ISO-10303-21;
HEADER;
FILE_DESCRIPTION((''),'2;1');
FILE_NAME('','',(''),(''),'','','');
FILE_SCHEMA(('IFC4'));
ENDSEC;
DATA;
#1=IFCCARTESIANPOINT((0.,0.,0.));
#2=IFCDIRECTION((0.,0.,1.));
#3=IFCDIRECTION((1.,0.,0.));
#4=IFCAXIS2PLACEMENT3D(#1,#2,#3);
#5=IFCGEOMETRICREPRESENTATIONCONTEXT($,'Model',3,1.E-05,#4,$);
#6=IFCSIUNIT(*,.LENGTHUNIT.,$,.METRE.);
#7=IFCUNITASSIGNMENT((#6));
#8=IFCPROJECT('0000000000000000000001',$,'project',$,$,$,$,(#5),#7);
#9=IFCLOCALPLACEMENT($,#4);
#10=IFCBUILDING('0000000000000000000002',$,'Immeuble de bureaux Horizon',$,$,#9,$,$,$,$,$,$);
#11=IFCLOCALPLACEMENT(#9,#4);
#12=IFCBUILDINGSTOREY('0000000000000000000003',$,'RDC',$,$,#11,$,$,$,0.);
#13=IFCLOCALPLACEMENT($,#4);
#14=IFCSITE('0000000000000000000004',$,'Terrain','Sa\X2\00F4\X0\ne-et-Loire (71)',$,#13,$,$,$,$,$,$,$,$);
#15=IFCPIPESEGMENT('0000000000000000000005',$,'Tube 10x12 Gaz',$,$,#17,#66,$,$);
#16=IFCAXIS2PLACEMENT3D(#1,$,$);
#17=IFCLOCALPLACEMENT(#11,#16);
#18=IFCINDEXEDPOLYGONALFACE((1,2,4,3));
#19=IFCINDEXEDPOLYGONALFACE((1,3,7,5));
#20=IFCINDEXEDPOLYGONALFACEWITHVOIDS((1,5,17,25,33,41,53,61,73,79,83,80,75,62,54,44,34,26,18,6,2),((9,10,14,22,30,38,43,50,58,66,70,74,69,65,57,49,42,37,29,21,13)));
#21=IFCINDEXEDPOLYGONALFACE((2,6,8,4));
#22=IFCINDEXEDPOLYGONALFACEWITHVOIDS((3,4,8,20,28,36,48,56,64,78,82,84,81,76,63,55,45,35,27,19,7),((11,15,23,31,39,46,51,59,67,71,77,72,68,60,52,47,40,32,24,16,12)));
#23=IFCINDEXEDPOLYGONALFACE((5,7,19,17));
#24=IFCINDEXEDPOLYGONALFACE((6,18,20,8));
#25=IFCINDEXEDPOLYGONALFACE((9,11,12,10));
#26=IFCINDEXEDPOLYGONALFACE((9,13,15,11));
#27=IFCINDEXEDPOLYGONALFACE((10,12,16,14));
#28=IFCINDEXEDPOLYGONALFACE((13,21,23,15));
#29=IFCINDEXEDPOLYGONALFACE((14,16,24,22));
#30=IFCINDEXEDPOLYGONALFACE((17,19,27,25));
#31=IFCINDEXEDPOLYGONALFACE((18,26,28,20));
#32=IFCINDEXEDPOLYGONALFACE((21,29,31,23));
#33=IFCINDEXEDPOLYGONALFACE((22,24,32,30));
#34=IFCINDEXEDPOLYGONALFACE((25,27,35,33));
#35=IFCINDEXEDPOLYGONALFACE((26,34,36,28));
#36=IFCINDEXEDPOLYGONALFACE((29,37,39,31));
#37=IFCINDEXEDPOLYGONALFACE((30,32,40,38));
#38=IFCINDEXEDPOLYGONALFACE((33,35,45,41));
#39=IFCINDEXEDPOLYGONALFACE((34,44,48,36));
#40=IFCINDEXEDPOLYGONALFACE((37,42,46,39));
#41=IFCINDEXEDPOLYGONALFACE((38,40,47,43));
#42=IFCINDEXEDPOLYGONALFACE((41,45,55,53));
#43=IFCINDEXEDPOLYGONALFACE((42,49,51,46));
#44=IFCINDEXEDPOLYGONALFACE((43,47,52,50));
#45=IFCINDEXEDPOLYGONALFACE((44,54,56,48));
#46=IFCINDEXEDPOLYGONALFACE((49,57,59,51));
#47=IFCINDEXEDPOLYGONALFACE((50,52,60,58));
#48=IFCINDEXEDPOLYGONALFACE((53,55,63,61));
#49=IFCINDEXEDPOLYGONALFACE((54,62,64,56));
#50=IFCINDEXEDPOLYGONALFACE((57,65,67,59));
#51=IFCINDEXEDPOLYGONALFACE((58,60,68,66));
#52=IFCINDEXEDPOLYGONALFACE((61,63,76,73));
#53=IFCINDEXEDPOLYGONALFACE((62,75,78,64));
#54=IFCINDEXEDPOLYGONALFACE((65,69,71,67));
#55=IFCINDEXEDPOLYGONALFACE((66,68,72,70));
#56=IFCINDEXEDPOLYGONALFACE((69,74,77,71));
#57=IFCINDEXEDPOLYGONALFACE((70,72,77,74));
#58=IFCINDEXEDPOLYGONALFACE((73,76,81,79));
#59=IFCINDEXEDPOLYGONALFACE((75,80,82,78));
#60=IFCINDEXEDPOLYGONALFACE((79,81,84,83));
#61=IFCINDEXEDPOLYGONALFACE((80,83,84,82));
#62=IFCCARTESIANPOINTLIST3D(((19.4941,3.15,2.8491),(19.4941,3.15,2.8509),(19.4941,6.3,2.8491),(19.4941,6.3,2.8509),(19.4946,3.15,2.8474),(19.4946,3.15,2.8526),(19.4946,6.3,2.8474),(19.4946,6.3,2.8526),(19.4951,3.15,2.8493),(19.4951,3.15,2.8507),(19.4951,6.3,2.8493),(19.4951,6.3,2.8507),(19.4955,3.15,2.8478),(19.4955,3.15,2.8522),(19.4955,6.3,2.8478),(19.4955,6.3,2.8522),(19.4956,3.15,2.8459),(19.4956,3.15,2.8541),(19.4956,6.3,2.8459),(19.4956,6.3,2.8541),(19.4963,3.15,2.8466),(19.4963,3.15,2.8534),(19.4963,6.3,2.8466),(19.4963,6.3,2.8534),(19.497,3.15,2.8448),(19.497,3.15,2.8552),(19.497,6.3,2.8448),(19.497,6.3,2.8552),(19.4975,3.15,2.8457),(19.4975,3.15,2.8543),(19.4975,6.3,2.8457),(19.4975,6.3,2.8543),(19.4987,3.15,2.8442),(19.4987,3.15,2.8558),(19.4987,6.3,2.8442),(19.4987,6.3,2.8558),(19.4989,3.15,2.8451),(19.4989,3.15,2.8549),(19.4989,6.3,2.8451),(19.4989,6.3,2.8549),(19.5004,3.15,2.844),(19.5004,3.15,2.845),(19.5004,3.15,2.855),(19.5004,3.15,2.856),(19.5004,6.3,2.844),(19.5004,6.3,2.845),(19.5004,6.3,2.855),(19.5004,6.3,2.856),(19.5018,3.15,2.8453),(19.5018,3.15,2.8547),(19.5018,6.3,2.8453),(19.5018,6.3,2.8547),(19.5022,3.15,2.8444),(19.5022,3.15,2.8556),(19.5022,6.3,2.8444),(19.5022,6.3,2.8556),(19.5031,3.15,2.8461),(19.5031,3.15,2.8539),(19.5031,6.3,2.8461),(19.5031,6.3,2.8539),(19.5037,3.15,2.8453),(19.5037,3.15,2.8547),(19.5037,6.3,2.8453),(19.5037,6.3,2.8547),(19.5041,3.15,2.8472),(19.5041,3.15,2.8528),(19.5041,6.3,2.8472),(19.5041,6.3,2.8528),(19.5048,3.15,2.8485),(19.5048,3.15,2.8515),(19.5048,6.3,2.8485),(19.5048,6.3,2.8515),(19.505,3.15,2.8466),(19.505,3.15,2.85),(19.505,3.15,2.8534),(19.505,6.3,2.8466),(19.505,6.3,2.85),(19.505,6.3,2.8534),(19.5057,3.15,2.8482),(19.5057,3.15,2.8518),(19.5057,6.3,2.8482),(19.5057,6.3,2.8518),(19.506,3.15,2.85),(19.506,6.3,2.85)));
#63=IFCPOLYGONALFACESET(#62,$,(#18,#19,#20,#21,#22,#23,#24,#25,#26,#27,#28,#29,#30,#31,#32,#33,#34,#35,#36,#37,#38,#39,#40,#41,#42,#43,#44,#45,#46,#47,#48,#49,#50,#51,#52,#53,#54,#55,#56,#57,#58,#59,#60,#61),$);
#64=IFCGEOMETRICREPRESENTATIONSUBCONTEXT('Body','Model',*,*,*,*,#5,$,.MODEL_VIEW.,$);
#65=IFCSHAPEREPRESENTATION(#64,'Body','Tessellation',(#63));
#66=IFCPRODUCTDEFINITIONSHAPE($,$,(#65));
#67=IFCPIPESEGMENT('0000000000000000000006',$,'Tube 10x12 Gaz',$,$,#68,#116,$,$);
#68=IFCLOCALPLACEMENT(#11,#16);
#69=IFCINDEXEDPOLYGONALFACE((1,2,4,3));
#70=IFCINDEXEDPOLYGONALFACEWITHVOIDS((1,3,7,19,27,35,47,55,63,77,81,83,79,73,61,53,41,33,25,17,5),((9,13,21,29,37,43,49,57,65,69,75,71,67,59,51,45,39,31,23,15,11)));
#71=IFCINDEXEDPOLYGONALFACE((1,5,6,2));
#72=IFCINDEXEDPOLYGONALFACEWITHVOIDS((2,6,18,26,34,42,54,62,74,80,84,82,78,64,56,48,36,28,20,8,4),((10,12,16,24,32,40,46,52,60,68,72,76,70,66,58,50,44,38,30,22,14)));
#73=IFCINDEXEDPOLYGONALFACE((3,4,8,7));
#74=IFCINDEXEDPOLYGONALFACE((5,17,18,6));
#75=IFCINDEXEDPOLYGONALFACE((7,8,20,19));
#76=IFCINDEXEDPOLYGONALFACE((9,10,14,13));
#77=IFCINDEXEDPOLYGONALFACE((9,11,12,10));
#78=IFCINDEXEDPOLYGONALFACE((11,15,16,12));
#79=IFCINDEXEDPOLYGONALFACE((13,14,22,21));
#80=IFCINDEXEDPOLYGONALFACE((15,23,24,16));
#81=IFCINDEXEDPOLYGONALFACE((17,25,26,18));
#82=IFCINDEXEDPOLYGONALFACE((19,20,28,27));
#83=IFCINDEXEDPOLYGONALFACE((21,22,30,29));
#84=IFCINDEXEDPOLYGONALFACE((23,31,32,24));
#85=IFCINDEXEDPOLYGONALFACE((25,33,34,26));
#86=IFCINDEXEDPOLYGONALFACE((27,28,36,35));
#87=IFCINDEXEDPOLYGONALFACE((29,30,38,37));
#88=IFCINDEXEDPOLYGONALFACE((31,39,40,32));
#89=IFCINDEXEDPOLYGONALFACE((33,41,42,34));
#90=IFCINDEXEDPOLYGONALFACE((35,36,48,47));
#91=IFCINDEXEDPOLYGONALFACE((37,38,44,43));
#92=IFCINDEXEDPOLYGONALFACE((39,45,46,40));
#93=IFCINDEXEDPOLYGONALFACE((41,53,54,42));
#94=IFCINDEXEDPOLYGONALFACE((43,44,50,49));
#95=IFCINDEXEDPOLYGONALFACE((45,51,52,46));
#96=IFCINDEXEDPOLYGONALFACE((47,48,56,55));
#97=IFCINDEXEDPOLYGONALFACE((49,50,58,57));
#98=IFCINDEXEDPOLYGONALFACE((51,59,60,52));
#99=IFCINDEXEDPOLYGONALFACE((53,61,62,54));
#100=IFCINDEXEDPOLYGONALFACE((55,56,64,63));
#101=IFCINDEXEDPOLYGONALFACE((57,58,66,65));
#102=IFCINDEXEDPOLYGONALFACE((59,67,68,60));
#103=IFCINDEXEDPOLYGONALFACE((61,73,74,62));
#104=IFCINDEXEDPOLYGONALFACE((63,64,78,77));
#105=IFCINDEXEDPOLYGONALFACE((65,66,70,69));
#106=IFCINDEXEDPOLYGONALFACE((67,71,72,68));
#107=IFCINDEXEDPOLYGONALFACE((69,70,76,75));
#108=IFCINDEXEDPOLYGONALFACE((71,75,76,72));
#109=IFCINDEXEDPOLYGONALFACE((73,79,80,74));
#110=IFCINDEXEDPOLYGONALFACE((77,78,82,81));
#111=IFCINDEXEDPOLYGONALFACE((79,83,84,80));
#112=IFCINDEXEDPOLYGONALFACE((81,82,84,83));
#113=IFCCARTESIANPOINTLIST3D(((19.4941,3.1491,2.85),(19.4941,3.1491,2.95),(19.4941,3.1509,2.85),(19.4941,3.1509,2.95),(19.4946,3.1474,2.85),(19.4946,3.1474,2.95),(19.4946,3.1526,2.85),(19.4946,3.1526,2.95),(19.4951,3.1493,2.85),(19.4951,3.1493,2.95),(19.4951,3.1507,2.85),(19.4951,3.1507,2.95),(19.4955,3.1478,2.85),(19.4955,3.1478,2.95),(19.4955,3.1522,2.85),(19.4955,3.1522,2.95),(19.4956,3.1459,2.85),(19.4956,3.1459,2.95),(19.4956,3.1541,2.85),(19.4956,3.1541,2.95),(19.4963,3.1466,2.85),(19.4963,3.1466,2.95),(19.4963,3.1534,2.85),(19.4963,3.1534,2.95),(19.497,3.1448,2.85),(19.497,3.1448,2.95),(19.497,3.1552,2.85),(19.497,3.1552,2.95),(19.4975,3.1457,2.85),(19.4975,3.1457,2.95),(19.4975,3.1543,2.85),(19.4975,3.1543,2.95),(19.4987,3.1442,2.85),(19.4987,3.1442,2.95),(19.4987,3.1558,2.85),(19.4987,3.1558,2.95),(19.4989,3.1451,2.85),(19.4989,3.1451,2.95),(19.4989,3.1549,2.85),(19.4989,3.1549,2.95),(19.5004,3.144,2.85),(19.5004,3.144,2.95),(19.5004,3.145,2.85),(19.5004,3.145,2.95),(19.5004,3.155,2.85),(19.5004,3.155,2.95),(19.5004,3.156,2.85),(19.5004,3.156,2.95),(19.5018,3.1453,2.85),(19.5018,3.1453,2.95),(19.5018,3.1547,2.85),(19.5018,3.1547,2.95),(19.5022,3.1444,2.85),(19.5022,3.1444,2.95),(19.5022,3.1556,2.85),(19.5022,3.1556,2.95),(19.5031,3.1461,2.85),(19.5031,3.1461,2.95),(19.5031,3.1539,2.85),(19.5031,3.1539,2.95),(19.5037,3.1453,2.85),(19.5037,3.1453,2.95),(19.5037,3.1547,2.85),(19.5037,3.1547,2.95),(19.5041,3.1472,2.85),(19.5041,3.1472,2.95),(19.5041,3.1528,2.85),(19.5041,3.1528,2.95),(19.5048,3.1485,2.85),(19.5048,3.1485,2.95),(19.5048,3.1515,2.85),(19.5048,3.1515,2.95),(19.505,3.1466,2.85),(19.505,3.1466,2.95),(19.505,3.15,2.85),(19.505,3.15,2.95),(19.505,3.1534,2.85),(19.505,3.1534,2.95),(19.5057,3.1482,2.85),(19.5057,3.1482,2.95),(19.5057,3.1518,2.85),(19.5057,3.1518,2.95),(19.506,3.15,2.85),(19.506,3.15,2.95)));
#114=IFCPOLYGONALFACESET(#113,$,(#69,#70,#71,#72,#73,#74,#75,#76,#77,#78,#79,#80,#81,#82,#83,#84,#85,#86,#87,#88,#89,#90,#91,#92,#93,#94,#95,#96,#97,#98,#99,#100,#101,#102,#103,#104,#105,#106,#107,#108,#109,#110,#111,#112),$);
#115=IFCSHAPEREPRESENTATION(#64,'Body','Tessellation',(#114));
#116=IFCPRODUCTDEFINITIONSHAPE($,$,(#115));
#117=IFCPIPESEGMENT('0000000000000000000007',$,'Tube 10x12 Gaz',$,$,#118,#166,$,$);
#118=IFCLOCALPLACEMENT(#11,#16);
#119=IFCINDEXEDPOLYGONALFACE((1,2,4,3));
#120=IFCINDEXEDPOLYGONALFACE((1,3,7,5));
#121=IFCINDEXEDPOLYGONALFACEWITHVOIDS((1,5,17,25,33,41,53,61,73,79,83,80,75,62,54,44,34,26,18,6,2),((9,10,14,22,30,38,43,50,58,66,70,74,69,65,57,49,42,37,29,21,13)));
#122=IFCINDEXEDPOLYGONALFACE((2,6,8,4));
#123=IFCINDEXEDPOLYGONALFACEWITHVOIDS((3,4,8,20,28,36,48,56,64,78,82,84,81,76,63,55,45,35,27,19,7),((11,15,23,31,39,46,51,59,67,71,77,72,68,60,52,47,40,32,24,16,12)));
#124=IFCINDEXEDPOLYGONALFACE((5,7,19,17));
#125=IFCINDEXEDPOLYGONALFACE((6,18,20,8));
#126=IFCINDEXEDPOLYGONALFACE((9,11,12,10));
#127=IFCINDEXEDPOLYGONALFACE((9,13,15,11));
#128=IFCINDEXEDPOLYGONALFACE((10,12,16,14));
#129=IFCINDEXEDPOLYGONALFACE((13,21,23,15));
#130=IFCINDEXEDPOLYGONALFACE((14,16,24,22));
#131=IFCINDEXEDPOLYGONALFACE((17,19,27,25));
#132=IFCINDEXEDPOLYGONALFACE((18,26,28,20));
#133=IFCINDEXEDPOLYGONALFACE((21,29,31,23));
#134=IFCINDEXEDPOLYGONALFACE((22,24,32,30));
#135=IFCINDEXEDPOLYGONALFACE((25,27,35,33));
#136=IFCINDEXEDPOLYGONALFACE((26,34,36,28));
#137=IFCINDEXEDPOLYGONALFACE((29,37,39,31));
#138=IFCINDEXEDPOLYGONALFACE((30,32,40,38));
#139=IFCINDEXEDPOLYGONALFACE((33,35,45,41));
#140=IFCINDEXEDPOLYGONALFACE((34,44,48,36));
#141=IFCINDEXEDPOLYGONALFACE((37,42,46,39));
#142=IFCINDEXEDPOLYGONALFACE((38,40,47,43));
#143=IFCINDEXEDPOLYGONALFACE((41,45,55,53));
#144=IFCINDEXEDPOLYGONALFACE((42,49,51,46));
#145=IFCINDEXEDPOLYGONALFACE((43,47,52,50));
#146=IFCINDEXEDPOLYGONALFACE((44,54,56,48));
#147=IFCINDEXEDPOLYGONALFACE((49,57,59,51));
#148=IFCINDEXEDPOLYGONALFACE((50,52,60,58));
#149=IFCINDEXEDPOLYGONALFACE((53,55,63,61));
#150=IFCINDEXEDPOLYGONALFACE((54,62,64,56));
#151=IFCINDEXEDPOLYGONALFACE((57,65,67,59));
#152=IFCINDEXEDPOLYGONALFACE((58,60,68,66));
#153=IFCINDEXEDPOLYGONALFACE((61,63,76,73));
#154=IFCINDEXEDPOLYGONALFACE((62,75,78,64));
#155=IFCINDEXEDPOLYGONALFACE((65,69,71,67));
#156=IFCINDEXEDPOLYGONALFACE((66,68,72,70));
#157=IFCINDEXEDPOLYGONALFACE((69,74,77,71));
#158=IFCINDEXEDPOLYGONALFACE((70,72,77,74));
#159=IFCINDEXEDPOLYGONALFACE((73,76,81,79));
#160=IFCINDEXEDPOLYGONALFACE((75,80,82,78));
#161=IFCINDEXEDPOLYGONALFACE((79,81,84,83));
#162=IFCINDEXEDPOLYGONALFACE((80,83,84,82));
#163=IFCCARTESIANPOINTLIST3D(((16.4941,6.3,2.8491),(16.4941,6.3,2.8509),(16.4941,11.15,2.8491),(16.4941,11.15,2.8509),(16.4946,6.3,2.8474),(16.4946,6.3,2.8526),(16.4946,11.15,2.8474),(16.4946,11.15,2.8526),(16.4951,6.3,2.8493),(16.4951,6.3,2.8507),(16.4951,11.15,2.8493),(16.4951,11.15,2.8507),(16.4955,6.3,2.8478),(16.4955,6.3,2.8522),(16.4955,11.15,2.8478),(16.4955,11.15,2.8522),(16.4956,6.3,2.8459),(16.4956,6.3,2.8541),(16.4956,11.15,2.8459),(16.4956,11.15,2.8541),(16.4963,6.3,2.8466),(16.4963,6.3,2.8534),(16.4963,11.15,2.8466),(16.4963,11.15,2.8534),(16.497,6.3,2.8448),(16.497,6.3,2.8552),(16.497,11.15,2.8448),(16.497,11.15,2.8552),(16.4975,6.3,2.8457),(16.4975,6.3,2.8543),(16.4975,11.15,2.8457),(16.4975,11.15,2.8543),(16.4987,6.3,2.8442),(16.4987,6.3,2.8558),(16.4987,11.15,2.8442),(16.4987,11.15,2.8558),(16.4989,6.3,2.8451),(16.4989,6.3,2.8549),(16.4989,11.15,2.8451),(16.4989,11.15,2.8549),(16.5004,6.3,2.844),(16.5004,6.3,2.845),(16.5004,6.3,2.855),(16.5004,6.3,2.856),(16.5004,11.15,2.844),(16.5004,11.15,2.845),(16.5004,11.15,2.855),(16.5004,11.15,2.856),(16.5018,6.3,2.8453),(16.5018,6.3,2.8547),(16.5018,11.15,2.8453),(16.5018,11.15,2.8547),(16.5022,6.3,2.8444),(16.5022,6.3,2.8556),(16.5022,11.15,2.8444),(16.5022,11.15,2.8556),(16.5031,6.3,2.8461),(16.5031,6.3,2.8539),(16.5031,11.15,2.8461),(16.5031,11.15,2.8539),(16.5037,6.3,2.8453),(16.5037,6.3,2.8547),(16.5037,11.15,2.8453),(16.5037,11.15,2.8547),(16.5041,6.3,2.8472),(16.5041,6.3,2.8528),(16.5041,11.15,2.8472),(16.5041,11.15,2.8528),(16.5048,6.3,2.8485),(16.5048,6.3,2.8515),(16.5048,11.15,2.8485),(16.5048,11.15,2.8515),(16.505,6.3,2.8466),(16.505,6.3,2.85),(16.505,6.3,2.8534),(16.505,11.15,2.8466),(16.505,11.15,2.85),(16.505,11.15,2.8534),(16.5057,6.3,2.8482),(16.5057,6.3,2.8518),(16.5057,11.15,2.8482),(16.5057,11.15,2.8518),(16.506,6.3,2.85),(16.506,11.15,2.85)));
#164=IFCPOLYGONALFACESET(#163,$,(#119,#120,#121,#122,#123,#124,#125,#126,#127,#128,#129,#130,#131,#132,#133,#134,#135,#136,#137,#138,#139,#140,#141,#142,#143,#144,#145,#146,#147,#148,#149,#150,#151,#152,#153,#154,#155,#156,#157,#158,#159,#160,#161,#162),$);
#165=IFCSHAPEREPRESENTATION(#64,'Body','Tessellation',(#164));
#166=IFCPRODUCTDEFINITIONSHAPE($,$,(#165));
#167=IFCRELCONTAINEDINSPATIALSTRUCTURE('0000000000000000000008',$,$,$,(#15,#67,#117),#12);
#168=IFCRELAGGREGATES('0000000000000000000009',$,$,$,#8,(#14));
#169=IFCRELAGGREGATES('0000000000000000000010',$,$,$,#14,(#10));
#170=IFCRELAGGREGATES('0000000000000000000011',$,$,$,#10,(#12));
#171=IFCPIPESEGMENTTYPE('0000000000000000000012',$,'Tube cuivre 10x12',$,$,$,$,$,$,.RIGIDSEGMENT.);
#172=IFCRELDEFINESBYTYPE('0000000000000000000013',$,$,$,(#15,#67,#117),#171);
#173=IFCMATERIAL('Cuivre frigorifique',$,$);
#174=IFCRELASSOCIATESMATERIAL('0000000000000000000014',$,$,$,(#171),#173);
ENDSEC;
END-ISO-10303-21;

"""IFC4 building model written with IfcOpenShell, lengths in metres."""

from ifc_helpers import new_model, si_unit, frame, origin_with_axes, place, context, subcontext, project, spatial, hollow_circle, extrude, material, type_object, element, save


model = new_model("IFC4")

# Units and contexts
model_context = context("Model", 3, precision=1e-05, world=origin_with_axes())
body_context = subcontext(model_context, "Body", "Model", "MODEL_VIEW")
ifc_project = project(units=[si_unit("LENGTHUNIT", "METRE")], contexts=[model_context])

# Site, building, storey
site_placement = place(None, origin_with_axes())
site = spatial("IfcSite", under=ifc_project, at=site_placement, Name="Terrain", Description="Saône-et-Loire (71)")
building_placement = place(None, origin_with_axes())
building = spatial("IfcBuilding", under=site, at=building_placement, Name="Immeuble de bureaux Horizon")
storey_placement = place(building_placement, origin_with_axes())
storey = spatial("IfcBuildingStorey", under=building, at=storey_placement, Name="RDC", Elevation=0.0)

# Pipe segments
ifc_material_1 = material(Name="Cuivre frigorifique")
pipe_segment_type_1 = type_object("IfcPipeSegmentType", Name="Tube cuivre 10x12", PredefinedType="RIGIDSEGMENT", material=ifc_material_1)
pipe_segment_1_placement = place(storey_placement, frame((19.5, 6.3, 2.85), z_axis=(0.0, -1.0, 0.0), x_axis=(1.0, 0.0, 0.0)))
element("IfcPipeSegment", 1, at=pipe_segment_1_placement, inside=storey, type_object=pipe_segment_type_1, Name="Tube 10x12 Gaz", context=body_context, shape_type="SweptSolid", body=[
    extrude(hollow_circle(Radius=0.006, WallThickness=0.001), origin_with_axes(), (0.0, 0.0, 1.0), 3.15),
])
pipe_segment_2_placement = place(storey_placement, frame((19.5, 3.15, 2.85), z_axis=(0.0, 0.0, 1.0), x_axis=(1.0, 0.0, 0.0)))
element("IfcPipeSegment", 2, at=pipe_segment_2_placement, inside=storey, type_object=pipe_segment_type_1, Name="Tube 10x12 Gaz", context=body_context, shape_type="SweptSolid", body=[
    extrude(hollow_circle(Radius=0.006, WallThickness=0.001), origin_with_axes(), (0.0, 0.0, 1.0), 0.1),
])
for number, where, z_axis, x_axis, name in (
    (3, (16.5, 6.3, 2.85), (0.0, 1.0, 0.0), (1.0, 0.0, 0.0), "Tube 10x12 Gaz"),
):
    element("IfcPipeSegment", number, at=place(storey_placement, frame(where, z_axis=z_axis, x_axis=x_axis)), inside=storey, type_object=pipe_segment_type_1, Name=name, context=body_context, shape_type="SweptSolid", body=[
        extrude(hollow_circle(Radius=0.006, WallThickness=0.001), origin_with_axes(), (0.0, 0.0, 1.0), 4.85),
    ])

save(model, "model.ifc")
